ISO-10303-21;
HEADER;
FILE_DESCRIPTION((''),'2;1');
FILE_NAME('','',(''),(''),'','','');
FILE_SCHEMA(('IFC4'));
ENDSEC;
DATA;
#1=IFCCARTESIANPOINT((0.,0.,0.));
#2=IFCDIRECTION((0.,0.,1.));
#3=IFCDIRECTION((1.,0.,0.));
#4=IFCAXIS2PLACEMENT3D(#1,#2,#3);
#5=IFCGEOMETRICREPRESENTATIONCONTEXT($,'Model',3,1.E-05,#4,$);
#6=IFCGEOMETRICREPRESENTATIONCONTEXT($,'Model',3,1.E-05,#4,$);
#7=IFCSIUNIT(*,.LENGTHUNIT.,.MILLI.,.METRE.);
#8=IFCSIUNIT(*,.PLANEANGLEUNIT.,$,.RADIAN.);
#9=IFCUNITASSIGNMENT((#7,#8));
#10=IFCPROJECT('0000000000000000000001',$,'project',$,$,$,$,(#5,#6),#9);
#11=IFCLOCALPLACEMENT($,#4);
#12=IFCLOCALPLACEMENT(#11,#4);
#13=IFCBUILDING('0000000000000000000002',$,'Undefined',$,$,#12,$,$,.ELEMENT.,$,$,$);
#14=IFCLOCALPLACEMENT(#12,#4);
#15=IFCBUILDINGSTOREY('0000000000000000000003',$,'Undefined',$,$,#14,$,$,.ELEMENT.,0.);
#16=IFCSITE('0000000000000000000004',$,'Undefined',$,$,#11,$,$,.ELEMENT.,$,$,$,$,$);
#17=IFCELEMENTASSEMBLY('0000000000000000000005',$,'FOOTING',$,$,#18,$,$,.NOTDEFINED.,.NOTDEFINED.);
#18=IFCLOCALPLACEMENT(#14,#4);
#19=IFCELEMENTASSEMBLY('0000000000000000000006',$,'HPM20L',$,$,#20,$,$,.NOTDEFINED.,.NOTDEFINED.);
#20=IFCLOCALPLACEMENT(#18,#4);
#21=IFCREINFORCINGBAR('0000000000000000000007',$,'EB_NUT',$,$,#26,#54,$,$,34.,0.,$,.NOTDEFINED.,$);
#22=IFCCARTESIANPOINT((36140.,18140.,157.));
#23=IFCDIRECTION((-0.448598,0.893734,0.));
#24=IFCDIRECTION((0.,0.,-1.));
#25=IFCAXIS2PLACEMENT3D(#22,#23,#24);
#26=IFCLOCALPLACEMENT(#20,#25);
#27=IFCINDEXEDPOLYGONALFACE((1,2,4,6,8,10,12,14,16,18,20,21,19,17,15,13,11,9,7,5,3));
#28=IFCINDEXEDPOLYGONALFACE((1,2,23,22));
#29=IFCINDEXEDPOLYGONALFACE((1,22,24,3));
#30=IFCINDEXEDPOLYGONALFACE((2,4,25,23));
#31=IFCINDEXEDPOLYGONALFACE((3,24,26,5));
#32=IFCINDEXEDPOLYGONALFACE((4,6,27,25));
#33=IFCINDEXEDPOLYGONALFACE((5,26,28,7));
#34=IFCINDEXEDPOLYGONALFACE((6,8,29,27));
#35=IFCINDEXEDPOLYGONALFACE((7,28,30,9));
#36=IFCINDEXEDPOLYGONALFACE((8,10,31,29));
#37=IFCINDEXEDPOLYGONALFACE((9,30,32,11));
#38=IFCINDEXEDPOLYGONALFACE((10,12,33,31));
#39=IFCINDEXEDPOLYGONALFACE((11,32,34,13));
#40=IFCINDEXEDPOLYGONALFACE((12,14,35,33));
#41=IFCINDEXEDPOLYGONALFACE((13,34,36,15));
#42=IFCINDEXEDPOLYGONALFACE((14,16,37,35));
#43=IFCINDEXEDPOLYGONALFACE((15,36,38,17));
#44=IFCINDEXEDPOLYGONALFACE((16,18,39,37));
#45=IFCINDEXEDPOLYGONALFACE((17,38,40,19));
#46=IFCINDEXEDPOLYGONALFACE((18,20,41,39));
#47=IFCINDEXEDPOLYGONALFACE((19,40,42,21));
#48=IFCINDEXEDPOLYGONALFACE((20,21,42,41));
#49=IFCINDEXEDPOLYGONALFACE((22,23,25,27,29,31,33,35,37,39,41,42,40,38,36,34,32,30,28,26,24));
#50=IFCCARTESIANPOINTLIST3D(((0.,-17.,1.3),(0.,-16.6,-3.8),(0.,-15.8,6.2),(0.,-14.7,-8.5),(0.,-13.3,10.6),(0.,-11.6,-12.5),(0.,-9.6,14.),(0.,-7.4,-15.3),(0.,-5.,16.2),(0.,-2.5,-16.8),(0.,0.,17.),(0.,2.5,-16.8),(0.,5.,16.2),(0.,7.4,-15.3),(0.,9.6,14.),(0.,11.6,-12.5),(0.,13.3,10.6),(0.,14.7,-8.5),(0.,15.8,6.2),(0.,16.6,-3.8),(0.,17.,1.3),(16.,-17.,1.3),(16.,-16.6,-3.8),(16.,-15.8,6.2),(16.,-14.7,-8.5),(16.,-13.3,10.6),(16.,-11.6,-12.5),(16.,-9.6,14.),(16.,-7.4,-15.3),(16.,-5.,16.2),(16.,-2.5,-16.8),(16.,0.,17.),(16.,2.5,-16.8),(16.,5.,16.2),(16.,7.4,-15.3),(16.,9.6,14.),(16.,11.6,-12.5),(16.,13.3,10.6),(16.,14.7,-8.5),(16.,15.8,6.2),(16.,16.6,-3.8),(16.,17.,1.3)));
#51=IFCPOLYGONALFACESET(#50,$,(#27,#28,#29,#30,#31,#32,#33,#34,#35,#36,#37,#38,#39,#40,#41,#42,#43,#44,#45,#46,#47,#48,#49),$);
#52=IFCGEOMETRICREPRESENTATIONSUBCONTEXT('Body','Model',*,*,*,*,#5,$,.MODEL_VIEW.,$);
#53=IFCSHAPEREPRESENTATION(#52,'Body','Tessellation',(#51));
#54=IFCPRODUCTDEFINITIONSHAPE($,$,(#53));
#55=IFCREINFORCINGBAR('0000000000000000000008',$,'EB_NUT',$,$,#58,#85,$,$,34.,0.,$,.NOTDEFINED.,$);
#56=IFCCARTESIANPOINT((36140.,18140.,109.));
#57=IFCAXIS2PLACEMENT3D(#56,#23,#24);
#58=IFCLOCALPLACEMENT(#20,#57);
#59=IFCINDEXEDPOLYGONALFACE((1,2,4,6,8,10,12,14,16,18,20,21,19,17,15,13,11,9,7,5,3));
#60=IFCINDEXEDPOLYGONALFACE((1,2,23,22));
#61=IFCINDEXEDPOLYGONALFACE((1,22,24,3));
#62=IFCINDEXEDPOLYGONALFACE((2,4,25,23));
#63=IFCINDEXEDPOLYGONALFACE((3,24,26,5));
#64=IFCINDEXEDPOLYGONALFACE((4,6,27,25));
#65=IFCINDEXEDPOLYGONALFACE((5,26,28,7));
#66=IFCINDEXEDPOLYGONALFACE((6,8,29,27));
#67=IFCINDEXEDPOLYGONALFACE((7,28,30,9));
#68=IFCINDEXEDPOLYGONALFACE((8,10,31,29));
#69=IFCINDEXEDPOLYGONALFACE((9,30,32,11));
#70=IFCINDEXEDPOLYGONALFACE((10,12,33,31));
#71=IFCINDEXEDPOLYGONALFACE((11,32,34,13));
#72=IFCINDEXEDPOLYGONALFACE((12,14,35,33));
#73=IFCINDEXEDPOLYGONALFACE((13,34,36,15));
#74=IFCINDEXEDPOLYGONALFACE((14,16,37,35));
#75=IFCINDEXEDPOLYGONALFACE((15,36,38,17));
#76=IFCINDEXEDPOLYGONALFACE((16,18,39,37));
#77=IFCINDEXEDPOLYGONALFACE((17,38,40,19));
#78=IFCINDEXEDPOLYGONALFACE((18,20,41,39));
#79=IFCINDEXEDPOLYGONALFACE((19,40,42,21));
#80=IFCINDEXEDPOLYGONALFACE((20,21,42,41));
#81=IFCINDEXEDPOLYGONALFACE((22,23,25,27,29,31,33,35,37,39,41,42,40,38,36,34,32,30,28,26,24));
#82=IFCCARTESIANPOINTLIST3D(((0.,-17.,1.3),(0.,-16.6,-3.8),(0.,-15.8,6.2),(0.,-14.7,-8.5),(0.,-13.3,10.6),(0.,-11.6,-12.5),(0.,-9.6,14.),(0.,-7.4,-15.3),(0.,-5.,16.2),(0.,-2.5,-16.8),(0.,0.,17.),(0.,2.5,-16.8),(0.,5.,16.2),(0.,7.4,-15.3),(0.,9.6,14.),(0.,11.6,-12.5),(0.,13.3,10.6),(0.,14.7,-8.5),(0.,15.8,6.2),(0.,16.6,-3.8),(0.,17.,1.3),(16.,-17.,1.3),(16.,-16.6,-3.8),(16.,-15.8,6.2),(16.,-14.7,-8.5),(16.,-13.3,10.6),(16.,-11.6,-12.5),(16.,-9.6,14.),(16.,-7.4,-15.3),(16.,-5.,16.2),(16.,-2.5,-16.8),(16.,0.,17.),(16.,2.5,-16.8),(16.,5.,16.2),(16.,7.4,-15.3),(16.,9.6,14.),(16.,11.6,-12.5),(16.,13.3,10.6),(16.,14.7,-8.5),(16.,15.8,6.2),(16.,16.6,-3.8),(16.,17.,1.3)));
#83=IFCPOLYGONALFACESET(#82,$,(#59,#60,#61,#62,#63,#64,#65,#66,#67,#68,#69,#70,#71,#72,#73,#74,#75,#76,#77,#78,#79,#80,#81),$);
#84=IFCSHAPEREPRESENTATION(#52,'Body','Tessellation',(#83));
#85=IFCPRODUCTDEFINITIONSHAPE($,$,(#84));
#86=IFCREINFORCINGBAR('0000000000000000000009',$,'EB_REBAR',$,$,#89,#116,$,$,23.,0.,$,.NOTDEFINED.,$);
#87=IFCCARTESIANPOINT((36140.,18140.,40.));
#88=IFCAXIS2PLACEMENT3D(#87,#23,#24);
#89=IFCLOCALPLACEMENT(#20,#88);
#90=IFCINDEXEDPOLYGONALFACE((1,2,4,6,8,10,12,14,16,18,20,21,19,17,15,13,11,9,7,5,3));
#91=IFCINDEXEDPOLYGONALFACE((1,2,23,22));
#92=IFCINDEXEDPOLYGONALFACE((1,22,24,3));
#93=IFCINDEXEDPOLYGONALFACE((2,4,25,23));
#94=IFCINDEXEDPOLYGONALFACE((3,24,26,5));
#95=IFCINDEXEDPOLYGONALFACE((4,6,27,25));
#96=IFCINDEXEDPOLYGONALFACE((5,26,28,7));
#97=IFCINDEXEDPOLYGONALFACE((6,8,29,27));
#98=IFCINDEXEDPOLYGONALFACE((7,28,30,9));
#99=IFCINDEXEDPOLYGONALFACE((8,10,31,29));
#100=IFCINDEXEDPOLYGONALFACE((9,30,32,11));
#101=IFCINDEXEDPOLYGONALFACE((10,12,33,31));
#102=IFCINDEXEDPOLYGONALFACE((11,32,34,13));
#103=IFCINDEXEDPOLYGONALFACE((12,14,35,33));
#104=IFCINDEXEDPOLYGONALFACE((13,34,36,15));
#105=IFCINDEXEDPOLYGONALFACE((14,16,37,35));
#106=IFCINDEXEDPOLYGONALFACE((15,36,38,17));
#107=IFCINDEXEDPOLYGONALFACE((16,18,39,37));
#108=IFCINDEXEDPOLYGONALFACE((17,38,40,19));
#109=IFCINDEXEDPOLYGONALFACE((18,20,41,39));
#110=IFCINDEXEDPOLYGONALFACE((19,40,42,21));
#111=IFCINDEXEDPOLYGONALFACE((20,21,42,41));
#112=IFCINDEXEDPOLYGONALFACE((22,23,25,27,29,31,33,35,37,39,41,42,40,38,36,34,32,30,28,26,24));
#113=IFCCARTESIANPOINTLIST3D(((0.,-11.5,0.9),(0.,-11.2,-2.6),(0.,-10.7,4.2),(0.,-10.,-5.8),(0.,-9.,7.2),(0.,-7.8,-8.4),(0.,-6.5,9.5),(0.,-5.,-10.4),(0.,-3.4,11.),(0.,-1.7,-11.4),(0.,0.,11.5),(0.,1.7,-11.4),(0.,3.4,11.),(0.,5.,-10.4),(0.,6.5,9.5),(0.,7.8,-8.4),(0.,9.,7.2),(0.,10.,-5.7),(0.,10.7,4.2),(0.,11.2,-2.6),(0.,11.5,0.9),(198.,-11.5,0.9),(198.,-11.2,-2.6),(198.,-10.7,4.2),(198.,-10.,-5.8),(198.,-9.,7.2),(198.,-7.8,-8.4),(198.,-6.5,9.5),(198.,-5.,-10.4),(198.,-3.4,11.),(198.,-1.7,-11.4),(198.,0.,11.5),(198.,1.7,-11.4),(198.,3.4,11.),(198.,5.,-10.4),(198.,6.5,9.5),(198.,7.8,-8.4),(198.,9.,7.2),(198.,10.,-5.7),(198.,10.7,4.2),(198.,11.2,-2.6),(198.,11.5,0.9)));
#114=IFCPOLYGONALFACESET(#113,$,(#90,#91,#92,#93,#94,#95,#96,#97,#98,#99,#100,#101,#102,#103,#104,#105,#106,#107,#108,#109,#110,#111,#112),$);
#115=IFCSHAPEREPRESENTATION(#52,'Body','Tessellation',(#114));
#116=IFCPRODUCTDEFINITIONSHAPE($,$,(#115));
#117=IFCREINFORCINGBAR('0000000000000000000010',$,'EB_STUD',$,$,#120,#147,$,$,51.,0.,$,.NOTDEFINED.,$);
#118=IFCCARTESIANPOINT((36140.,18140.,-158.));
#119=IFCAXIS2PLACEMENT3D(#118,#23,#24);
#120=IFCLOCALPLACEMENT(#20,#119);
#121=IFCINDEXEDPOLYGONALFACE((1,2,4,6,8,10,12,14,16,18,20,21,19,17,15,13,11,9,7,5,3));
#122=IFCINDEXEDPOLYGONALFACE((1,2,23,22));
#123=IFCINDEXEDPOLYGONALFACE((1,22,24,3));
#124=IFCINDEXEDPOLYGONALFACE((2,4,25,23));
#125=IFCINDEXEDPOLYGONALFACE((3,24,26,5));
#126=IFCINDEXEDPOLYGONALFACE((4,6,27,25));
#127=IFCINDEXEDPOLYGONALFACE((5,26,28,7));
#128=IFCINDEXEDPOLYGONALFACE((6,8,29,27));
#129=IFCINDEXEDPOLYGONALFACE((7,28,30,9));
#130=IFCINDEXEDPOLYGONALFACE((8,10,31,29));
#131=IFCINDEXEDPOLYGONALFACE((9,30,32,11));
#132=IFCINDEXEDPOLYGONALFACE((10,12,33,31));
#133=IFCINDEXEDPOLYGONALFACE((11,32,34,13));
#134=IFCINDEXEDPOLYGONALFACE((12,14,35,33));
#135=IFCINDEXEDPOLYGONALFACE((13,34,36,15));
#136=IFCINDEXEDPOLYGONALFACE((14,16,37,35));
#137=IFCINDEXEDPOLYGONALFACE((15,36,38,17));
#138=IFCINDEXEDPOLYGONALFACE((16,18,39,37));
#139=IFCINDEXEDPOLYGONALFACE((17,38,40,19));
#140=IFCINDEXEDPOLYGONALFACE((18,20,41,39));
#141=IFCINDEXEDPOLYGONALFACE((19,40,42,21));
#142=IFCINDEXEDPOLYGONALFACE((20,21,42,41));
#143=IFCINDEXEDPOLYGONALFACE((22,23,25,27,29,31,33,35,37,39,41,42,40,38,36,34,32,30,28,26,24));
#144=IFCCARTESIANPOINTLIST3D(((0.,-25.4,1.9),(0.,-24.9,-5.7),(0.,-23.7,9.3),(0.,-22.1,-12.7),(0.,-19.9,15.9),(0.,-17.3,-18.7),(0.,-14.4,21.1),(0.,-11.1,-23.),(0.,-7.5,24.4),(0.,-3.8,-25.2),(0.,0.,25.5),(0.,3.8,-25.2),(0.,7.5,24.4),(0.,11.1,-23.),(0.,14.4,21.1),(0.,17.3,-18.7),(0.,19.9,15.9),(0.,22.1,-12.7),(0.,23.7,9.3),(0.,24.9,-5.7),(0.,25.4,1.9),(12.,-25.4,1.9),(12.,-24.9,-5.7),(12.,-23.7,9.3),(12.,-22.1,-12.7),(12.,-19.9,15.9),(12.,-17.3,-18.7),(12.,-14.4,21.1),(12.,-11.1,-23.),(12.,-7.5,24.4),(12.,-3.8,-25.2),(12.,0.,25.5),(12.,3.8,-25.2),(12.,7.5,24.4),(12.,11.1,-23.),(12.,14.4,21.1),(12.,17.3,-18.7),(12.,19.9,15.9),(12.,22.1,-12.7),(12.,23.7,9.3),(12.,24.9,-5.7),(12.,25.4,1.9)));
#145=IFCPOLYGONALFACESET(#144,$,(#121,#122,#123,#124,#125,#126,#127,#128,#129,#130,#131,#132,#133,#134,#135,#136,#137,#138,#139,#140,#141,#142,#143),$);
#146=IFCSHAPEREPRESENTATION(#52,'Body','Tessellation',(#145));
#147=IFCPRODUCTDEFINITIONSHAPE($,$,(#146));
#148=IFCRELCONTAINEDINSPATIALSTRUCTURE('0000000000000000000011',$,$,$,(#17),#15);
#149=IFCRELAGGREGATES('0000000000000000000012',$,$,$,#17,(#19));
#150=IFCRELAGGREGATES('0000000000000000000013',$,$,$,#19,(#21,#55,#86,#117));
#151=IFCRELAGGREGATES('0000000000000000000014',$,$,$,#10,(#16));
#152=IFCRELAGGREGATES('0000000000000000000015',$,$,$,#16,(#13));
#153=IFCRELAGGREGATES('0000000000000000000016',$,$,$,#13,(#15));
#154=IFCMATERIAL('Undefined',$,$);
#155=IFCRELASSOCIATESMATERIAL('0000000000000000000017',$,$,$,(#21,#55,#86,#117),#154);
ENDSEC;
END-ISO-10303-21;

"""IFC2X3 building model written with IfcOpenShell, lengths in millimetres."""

from ifc_helpers import new_model, entity, si_unit, frame, origin_with_axes, place, context, subcontext, project, spatial, source, transform, mapped, material, element, aggregate, save


model = new_model("IFC2X3")

# Units and contexts
model_context_1 = context("Model", 3, precision=1e-05, world=origin_with_axes())
model_context_2 = context("Model", 3, precision=1e-05, world=origin_with_axes())
body_context = subcontext(model_context_1, "Body", "Model", "MODEL_VIEW")
ifc_project = project(units=[si_unit("LENGTHUNIT", "METRE", prefix="MILLI"), si_unit("PLANEANGLEUNIT", "RADIAN")], contexts=[model_context_1, model_context_2])

# Site, building, storey
site_placement = place(None, origin_with_axes())
site = spatial("IfcSite", under=ifc_project, at=site_placement, Name="Undefined", CompositionType="ELEMENT")
building_placement = place(site_placement, origin_with_axes())
building = spatial("IfcBuilding", under=site, at=building_placement, Name="Undefined", CompositionType="ELEMENT")
storey_placement = place(building_placement, origin_with_axes())
storey = spatial("IfcBuildingStorey", under=building, at=storey_placement, Name="Undefined", CompositionType="ELEMENT", Elevation=0.0)

# Element assembly
assembly_1_placement = place(storey_placement, origin_with_axes())
assembly_1 = element("IfcElementAssembly", 1, at=assembly_1_placement, inside=storey, Name="FOOTING", AssemblyPlace="NOTDEFINED", PredefinedType="NOTDEFINED")

# Element assembly
assembly_2_placement = place(assembly_1_placement, origin_with_axes())
assembly_2 = element("IfcElementAssembly", 2, at=assembly_2_placement, Name="HPM20L", AssemblyPlace="NOTDEFINED", PredefinedType="NOTDEFINED")
aggregate(assembly_1, [assembly_2])

# Shared definitions
ifc_material_1 = material(Name="Undefined")

# Reinforcing bars
shared_shape_1 = source(origin_with_axes(), body_context, "Body", "AdvancedSweptSolid", [
    entity("IfcSweptDiskSolid", entity("IfcTrimmedCurve", entity("IfcLine", entity("IfcCartesianPoint", [0.0, 0.0, 0.0]), entity("IfcVector", entity("IfcDirection", [1.0, 0.0, 0.0]), 1.0)), [entity("IfcParameterValue", 0.0)], [entity("IfcParameterValue", 16.0)], True, "PARAMETER"), 17.0, None, 0.0, 16.0),
])
reinforcing_bar_1_placement = place(assembly_2_placement, frame((36140.0, 18140.0, 157.0), z_axis=(-0.448598, 0.893734, 0.0), x_axis=(0.0, 0.0, -1.0)))
reinforcing_bar_1 = element("IfcReinforcingBar", 3, at=reinforcing_bar_1_placement, material=ifc_material_1, Name="EB_NUT", BarRole="NOTDEFINED", CrossSectionArea=0.0, NominalDiameter=34.0, context=body_context, shape_type="MappedRepresentation", body=[
    mapped(shared_shape_1, transform((0.0, 0.0, 0.0))),
])
shared_shape_2 = source(origin_with_axes(), body_context, "Body", "AdvancedSweptSolid", [
    entity("IfcSweptDiskSolid", entity("IfcTrimmedCurve", entity("IfcLine", entity("IfcCartesianPoint", [0.0, 0.0, 0.0]), entity("IfcVector", entity("IfcDirection", [1.0, 0.0, 0.0]), 1.0)), [entity("IfcParameterValue", 0.0)], [entity("IfcParameterValue", 16.0)], True, "PARAMETER"), 17.0, None, 0.0, 16.0),
])
reinforcing_bar_2_placement = place(assembly_2_placement, frame((36140.0, 18140.0, 109.0), z_axis=(-0.448598, 0.893734, 0.0), x_axis=(0.0, 0.0, -1.0)))
reinforcing_bar_2 = element("IfcReinforcingBar", 4, at=reinforcing_bar_2_placement, material=ifc_material_1, Name="EB_NUT", BarRole="NOTDEFINED", CrossSectionArea=0.0, NominalDiameter=34.0, context=body_context, shape_type="MappedRepresentation", body=[
    mapped(shared_shape_2, transform((0.0, 0.0, 0.0))),
])
shared_shape_3 = source(origin_with_axes(), body_context, "Body", "AdvancedSweptSolid", [
    entity("IfcSweptDiskSolid", entity("IfcTrimmedCurve", entity("IfcLine", entity("IfcCartesianPoint", [0.0, 0.0, 0.0]), entity("IfcVector", entity("IfcDirection", [1.0, 0.0, 0.0]), 1.0)), [entity("IfcParameterValue", 0.0)], [entity("IfcParameterValue", 198.0)], True, "PARAMETER"), 11.5, None, 0.0, 198.0),
])
reinforcing_bar_3_placement = place(assembly_2_placement, frame((36140.0, 18140.0, 40.0), z_axis=(-0.448598, 0.893734, 0.0), x_axis=(0.0, 0.0, -1.0)))
reinforcing_bar_3 = element("IfcReinforcingBar", 5, at=reinforcing_bar_3_placement, material=ifc_material_1, Name="EB_REBAR", BarRole="NOTDEFINED", CrossSectionArea=0.0, NominalDiameter=23.0, context=body_context, shape_type="MappedRepresentation", body=[
    mapped(shared_shape_3, transform((0.0, 0.0, 0.0))),
])
shared_shape_4 = source(origin_with_axes(), body_context, "Body", "AdvancedSweptSolid", [
    entity("IfcSweptDiskSolid", entity("IfcTrimmedCurve", entity("IfcLine", entity("IfcCartesianPoint", [0.0, 0.0, 0.0]), entity("IfcVector", entity("IfcDirection", [1.0, 0.0, 0.0]), 1.0)), [entity("IfcParameterValue", 0.0)], [entity("IfcParameterValue", 12.0)], True, "PARAMETER"), 25.5, None, 0.0, 12.0),
])
reinforcing_bar_4_placement = place(assembly_2_placement, frame((36140.0, 18140.0, -158.0), z_axis=(-0.448598, 0.893734, 0.0), x_axis=(0.0, 0.0, -1.0)))
reinforcing_bar_4 = element("IfcReinforcingBar", 6, at=reinforcing_bar_4_placement, material=ifc_material_1, Name="EB_STUD", BarRole="NOTDEFINED", CrossSectionArea=0.0, NominalDiameter=51.0, context=body_context, shape_type="MappedRepresentation", body=[
    mapped(shared_shape_4, transform((0.0, 0.0, 0.0))),
])
aggregate(assembly_2, [reinforcing_bar_1, reinforcing_bar_2, reinforcing_bar_3, reinforcing_bar_4])

save(model, "model.ifc")
